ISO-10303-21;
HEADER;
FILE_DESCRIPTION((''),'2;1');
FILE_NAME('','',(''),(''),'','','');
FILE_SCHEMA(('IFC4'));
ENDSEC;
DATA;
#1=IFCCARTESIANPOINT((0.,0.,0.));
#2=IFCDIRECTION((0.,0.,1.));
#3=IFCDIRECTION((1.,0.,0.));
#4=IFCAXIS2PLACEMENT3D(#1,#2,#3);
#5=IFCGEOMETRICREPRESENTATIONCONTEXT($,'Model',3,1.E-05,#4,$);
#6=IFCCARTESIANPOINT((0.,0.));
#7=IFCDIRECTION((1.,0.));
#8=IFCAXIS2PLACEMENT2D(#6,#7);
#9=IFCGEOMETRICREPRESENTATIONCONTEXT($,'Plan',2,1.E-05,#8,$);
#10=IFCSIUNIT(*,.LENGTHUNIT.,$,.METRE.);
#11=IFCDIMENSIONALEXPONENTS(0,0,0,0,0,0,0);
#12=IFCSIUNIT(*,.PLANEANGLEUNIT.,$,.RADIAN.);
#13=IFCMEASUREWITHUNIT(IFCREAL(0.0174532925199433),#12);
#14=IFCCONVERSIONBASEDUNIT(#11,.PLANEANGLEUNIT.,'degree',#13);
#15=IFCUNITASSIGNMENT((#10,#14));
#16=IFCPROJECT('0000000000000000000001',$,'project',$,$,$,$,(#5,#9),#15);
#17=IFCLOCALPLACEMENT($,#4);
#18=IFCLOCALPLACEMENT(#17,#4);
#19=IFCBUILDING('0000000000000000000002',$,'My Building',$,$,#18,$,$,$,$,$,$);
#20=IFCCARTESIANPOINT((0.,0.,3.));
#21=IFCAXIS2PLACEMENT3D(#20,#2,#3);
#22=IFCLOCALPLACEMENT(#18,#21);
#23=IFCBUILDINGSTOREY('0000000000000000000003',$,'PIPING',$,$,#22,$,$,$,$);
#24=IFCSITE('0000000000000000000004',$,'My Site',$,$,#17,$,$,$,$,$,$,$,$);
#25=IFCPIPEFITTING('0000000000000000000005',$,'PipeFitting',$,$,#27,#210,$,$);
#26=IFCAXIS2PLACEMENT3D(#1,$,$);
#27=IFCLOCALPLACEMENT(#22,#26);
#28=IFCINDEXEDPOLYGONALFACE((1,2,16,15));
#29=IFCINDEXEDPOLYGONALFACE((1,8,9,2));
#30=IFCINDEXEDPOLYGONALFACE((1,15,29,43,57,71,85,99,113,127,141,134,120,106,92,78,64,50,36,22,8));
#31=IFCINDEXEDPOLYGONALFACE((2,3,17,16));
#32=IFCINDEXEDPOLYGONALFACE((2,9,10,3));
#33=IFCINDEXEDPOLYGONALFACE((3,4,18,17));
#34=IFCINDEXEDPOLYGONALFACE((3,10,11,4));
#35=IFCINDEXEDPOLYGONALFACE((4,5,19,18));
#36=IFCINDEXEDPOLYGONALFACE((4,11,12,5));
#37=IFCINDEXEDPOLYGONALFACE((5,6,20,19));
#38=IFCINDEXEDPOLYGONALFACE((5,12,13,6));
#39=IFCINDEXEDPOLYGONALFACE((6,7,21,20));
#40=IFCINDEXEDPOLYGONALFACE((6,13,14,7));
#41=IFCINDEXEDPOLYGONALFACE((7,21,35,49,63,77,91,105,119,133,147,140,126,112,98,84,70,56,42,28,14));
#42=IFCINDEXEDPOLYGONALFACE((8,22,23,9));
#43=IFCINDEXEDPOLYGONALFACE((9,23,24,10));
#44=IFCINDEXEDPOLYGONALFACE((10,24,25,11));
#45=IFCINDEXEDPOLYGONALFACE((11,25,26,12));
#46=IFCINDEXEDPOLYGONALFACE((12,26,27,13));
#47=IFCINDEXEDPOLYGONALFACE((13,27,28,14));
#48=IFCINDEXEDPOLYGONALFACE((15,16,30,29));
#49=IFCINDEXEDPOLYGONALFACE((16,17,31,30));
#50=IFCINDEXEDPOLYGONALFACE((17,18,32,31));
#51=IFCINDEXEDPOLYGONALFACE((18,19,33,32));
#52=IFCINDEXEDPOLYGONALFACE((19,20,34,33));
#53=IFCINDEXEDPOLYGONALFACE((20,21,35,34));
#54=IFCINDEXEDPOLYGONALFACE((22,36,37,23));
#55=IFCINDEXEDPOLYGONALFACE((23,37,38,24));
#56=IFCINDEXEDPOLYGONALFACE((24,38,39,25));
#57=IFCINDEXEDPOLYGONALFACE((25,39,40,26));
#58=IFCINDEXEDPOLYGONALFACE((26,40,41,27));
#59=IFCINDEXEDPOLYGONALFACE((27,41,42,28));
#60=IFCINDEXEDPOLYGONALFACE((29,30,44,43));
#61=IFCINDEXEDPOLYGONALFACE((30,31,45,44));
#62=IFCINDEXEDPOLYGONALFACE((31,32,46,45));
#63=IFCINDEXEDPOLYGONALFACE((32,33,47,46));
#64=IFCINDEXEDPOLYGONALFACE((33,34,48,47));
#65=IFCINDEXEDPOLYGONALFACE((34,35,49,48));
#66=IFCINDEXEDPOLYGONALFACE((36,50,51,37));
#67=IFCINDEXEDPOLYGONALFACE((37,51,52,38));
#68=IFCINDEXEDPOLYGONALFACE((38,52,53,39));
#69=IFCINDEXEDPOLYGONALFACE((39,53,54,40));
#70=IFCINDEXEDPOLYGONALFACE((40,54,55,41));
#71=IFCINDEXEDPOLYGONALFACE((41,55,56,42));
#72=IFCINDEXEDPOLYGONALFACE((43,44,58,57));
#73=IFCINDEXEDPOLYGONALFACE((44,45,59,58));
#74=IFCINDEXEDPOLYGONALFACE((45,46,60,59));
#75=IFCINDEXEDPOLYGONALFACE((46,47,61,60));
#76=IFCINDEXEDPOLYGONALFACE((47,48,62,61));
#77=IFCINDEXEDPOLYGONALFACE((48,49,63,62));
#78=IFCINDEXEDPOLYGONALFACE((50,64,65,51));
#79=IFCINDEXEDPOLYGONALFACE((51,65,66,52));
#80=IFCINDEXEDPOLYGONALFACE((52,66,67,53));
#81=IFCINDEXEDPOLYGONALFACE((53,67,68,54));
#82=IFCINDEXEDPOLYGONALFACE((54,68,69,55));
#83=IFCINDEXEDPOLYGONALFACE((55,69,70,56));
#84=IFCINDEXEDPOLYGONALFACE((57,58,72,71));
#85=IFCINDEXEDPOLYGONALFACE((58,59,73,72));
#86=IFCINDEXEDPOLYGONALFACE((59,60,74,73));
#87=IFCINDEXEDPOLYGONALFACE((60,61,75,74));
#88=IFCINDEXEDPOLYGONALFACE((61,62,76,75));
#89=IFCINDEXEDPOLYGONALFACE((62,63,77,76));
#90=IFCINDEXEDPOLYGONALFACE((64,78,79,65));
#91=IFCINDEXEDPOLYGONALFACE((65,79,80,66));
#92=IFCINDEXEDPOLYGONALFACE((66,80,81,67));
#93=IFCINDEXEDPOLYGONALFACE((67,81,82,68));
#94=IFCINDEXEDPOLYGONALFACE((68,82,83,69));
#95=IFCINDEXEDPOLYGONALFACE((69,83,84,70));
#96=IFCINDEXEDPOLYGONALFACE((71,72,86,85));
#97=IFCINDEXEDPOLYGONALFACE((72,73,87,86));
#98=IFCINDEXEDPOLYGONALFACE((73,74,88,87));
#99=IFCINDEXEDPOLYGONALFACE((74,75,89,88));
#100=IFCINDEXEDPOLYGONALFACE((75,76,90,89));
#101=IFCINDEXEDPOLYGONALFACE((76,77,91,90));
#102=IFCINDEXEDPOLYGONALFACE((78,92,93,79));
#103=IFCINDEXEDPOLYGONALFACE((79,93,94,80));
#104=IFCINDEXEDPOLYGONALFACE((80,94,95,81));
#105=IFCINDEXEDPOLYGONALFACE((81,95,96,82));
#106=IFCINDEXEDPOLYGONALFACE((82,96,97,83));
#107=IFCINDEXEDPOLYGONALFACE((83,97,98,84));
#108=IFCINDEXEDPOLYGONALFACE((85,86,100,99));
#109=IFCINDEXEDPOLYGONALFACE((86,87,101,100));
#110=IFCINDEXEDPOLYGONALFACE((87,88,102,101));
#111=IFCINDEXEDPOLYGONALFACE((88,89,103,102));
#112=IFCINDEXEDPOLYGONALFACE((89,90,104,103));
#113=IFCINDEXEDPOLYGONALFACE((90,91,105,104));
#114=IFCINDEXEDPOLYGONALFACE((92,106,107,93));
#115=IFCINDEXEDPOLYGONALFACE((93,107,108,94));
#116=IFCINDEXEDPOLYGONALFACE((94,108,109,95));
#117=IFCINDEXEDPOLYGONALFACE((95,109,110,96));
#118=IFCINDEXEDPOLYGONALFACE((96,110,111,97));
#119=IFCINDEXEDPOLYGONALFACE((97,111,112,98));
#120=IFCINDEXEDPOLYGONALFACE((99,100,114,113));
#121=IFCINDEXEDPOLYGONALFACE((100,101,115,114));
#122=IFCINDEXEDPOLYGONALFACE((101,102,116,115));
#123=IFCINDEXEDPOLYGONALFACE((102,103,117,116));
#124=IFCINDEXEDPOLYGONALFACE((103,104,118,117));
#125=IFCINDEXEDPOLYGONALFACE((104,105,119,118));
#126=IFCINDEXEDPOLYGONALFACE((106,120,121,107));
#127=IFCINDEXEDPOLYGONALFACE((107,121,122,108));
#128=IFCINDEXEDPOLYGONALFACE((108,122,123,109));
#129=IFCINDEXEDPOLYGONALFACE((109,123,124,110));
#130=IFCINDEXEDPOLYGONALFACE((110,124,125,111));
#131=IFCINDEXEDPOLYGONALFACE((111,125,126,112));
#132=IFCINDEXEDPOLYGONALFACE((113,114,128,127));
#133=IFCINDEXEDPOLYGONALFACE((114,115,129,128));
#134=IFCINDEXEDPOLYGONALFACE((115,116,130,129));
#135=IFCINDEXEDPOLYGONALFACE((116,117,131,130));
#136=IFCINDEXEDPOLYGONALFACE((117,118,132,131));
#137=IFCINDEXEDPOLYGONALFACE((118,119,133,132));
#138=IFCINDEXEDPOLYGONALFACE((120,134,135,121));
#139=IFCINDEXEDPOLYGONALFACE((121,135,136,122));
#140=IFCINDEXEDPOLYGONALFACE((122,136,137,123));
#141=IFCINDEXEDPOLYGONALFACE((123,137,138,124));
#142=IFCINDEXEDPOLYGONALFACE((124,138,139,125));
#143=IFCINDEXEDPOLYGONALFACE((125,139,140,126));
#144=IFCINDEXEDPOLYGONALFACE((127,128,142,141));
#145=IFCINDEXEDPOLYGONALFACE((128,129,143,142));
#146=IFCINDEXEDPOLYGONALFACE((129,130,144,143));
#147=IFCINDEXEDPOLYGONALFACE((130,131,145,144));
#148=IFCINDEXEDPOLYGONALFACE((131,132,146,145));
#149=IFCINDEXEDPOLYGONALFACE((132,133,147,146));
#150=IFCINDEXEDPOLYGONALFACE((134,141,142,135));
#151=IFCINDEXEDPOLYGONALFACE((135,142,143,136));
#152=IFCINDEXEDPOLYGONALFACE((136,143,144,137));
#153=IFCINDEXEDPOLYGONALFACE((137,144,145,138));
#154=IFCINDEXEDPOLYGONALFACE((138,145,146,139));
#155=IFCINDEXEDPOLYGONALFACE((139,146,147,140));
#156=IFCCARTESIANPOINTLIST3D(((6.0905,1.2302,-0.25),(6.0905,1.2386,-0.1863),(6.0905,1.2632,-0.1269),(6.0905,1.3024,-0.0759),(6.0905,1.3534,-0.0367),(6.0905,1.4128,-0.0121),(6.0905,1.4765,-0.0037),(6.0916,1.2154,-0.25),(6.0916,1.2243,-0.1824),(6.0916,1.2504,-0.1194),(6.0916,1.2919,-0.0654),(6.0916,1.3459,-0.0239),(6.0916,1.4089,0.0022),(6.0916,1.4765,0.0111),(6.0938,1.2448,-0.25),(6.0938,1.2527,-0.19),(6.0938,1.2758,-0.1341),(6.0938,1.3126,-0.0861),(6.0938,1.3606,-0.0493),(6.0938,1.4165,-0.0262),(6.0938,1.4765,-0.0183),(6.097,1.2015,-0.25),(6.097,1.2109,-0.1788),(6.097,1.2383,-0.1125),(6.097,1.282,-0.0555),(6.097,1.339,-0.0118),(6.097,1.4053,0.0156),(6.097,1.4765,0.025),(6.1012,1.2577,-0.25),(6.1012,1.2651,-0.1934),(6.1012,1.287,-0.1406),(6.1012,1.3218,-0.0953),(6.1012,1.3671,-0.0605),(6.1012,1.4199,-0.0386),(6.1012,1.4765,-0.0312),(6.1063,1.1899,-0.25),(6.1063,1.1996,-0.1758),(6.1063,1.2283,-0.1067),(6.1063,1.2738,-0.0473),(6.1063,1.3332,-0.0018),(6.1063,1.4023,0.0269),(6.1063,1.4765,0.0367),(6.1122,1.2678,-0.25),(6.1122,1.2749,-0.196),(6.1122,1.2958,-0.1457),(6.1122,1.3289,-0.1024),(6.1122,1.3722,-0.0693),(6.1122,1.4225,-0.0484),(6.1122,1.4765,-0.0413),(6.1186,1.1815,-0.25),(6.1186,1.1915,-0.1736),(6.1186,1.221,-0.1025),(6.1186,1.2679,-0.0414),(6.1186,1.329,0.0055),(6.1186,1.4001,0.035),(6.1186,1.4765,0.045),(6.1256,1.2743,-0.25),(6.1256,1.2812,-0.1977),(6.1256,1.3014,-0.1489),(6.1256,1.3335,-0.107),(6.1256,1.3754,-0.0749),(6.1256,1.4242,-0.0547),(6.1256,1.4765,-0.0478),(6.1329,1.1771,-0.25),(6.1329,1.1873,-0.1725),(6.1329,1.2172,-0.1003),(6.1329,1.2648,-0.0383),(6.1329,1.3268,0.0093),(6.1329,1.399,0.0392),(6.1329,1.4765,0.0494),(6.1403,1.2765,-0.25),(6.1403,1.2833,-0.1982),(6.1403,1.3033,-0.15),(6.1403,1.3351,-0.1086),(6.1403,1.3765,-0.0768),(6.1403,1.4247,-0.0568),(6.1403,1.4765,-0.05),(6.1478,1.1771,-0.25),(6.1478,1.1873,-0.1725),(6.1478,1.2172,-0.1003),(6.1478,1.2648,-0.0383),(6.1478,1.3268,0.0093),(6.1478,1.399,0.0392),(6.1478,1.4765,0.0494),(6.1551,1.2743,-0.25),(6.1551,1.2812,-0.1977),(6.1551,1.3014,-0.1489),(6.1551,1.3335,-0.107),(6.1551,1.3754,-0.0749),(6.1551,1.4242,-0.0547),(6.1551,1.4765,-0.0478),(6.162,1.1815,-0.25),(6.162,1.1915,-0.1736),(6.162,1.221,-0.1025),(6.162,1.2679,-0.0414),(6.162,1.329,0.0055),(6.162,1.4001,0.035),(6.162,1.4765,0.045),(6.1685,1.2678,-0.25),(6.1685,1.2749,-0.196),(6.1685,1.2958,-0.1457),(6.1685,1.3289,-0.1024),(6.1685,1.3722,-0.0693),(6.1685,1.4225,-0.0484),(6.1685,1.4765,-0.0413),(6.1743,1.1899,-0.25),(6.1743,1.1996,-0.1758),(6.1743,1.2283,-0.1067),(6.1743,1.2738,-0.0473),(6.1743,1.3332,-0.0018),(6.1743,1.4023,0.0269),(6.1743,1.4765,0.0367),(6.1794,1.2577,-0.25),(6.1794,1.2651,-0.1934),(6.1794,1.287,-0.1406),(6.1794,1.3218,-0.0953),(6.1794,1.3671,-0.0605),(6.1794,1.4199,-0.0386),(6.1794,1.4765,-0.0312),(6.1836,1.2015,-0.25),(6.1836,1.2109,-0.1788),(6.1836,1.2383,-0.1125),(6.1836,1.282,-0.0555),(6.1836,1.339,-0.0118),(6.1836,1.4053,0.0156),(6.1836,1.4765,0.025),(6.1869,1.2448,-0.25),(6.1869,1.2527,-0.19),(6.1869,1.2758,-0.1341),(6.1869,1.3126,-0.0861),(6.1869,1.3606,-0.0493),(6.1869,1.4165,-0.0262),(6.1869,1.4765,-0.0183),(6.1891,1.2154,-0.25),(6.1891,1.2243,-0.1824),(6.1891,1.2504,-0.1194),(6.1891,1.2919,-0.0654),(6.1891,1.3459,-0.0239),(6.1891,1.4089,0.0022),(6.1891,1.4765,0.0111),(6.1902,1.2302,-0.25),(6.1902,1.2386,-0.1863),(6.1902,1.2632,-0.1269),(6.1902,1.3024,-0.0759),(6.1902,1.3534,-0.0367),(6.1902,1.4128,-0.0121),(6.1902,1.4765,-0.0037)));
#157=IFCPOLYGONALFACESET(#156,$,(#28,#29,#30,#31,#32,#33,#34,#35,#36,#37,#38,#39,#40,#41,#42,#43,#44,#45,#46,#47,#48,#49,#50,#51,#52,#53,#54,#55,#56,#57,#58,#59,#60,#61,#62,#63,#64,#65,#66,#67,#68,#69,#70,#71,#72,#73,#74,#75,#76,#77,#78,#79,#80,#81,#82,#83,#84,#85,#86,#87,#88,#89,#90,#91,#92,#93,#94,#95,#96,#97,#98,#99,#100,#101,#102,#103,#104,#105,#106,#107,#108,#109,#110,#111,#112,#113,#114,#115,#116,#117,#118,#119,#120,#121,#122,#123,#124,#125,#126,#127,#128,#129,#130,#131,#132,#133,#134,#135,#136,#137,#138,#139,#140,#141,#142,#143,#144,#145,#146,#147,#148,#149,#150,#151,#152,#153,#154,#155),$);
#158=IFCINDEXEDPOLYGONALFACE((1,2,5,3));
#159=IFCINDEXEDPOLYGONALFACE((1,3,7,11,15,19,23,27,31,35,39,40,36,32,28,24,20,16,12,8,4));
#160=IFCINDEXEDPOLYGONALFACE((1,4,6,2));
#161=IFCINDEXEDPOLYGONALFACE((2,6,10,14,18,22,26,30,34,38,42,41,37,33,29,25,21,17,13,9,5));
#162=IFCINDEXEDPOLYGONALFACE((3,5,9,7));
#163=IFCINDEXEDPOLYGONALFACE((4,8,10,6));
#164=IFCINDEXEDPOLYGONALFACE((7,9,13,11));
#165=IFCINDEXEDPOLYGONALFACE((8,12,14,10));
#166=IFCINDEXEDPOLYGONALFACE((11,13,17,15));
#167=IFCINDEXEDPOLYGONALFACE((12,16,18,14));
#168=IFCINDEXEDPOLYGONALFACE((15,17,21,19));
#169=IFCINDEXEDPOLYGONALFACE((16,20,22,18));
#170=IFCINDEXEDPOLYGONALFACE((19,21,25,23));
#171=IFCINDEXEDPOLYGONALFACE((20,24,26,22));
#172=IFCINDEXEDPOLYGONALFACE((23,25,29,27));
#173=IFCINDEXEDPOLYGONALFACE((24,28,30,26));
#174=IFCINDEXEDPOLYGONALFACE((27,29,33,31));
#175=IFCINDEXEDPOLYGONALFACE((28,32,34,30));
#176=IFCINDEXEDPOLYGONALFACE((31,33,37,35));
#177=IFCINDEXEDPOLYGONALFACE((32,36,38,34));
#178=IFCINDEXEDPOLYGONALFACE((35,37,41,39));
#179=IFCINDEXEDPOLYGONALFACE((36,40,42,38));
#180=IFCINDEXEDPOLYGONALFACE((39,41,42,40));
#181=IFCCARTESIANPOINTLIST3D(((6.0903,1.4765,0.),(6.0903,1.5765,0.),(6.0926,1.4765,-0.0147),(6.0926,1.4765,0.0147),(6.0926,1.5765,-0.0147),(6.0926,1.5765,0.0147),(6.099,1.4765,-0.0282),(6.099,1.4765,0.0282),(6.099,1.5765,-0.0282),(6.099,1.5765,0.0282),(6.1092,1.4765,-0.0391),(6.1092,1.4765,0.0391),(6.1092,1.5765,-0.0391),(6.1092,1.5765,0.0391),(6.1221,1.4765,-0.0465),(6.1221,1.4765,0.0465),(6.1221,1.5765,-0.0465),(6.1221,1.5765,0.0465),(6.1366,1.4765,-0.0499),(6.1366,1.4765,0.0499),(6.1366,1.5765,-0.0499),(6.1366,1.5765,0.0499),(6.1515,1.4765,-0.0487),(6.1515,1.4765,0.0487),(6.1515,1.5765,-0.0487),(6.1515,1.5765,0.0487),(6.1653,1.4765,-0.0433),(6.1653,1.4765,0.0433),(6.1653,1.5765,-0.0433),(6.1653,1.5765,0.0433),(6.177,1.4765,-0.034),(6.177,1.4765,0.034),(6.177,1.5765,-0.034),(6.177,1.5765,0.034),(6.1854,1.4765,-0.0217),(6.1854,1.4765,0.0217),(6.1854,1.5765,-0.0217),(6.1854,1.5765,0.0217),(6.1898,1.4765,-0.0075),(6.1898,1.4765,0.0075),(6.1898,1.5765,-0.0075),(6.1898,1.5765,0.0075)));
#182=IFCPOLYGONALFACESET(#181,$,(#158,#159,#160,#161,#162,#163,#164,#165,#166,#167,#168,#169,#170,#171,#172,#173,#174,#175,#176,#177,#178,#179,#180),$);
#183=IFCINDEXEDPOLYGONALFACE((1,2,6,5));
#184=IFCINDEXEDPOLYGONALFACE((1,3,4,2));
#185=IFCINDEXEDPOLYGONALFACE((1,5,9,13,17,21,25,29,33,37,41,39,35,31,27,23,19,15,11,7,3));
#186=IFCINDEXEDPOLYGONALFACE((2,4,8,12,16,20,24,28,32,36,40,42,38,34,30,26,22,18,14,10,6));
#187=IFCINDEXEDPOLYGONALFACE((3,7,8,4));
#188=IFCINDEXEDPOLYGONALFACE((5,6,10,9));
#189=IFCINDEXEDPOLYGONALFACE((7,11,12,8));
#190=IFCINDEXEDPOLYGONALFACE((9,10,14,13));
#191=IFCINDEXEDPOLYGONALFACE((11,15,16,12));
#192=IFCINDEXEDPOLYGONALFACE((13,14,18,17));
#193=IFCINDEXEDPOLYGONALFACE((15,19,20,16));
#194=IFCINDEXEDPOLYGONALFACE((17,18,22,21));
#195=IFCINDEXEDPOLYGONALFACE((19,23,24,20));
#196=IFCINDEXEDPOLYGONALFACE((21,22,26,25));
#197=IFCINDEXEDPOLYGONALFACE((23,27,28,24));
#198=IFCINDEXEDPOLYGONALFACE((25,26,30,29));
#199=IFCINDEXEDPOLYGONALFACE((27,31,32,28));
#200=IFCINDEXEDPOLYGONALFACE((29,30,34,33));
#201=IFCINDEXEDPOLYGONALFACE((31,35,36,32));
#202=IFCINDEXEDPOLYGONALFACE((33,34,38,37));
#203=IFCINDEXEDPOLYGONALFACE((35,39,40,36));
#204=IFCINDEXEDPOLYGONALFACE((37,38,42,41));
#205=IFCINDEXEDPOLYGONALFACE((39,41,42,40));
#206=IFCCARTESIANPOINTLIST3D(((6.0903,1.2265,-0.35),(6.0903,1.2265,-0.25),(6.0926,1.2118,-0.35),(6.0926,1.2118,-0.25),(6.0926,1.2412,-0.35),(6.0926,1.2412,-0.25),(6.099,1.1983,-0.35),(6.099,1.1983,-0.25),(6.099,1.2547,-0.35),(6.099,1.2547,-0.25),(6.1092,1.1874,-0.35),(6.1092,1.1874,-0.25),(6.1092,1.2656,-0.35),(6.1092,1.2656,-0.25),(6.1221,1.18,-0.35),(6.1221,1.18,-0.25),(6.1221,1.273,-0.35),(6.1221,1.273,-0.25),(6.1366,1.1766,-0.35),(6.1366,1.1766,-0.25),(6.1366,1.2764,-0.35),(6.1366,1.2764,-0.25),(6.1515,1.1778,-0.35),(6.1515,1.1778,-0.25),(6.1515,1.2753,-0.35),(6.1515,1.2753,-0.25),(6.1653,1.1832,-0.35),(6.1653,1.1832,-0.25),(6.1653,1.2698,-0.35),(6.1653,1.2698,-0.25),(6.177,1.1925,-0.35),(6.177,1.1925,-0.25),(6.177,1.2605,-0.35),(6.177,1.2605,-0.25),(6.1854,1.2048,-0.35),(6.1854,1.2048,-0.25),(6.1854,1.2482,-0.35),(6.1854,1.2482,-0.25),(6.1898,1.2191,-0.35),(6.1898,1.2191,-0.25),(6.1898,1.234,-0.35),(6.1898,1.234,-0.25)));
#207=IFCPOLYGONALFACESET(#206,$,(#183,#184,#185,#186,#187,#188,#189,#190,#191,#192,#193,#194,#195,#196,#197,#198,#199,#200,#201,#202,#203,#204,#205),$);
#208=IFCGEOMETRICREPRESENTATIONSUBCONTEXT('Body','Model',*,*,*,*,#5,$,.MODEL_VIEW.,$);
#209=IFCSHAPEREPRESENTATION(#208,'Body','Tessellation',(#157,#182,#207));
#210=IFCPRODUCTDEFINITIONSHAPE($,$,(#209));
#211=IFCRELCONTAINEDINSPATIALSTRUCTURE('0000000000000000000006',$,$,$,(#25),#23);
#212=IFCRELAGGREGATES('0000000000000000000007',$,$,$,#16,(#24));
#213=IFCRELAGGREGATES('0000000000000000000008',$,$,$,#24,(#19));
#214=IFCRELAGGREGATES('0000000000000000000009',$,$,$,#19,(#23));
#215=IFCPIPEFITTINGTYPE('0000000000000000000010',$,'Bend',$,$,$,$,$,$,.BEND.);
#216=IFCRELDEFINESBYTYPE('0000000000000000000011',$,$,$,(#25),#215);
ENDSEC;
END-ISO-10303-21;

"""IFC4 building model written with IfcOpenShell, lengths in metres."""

from ifc_helpers import new_model, entity, si_unit, converted_unit, frame, origin_with_axes, origin_2d_with_axis, place, context, subcontext, project, spatial, circle, extrude, source, transform, mapped, type_object, type_shapes, element, save


model = new_model("IFC4")

# Units and contexts
model_context = context("Model", 3, precision=1e-05, world=origin_with_axes())
plan_context = context("Plan", 2, precision=1e-05, world=origin_2d_with_axis())
body_context = subcontext(model_context, "Body", "Model", "MODEL_VIEW")
ifc_project = project(units=[si_unit("LENGTHUNIT", "METRE"), converted_unit("PLANEANGLEUNIT", "degree", entity("IfcReal", 0.0174532925199433), si_unit("PLANEANGLEUNIT", "RADIAN"), dimensions=[0, 0, 0, 0, 0, 0, 0])], contexts=[model_context, plan_context])

# Site, building, storey
site_placement = place(None, origin_with_axes())
site = spatial("IfcSite", under=ifc_project, at=site_placement, Name="My Site")
building_placement = place(site_placement, origin_with_axes())
building = spatial("IfcBuilding", under=site, at=building_placement, Name="My Building")
storey_placement = place(building_placement, frame((0.0, 0.0, 3.0), z_axis=(0.0, 0.0, 1.0), x_axis=(1.0, 0.0, 0.0)))
storey = spatial("IfcBuildingStorey", under=building, at=storey_placement, Name="PIPING")

# Pipe fitting
pipe_fitting_type = type_object("IfcPipeFittingType", Name="Bend", PredefinedType="BEND")
shared_shape = source(origin_with_axes(), body_context, "Body", "SolidModel", [
    entity("IfcSweptDiskSolid", entity("IfcIndexedPolyCurve", entity("IfcCartesianPointList3D", [[0.0, 0.0, -0.1], [0.0, -0.0732, -0.2768], [0.0, -0.25, -0.35]]), [entity("IfcArcIndex", [1, 2, 3])]), 0.05),
    extrude(circle(Radius=0.05), origin_with_axes(), (0.0, 0.0, -1.0), 0.1),
    extrude(circle(Radius=0.05), frame((0.0, -0.25, -0.35), z_axis=(0.0, -1.0, 0.0), x_axis=(1.0, 0.0, 0.0)), (0.0, 0.0, 1.0), 0.1),
])
type_shapes(pipe_fitting_type, [shared_shape])
for number, where, z_axis, x_axis, name in (
    (1, (6.1403, 1.5765, 0.0), (0.0, 1.0, 0.0), (-1.0, 0.0, 0.0), "PipeFitting"),
):
    element("IfcPipeFitting", number, at=place(storey_placement, frame(where, z_axis=z_axis, x_axis=x_axis)), inside=storey, type_object=pipe_fitting_type, Name=name, context=body_context, shape_type="MappedRepresentation", body=[
        mapped(shared_shape, transform((0.0, 0.0, 0.0), x_axis=(1.0, 0.0, 0.0), y_axis=(0.0, 1.0, 0.0), z_axis=(0.0, 0.0, 1.0), scale=1.0)),
    ])

save(model, "model.ifc")
